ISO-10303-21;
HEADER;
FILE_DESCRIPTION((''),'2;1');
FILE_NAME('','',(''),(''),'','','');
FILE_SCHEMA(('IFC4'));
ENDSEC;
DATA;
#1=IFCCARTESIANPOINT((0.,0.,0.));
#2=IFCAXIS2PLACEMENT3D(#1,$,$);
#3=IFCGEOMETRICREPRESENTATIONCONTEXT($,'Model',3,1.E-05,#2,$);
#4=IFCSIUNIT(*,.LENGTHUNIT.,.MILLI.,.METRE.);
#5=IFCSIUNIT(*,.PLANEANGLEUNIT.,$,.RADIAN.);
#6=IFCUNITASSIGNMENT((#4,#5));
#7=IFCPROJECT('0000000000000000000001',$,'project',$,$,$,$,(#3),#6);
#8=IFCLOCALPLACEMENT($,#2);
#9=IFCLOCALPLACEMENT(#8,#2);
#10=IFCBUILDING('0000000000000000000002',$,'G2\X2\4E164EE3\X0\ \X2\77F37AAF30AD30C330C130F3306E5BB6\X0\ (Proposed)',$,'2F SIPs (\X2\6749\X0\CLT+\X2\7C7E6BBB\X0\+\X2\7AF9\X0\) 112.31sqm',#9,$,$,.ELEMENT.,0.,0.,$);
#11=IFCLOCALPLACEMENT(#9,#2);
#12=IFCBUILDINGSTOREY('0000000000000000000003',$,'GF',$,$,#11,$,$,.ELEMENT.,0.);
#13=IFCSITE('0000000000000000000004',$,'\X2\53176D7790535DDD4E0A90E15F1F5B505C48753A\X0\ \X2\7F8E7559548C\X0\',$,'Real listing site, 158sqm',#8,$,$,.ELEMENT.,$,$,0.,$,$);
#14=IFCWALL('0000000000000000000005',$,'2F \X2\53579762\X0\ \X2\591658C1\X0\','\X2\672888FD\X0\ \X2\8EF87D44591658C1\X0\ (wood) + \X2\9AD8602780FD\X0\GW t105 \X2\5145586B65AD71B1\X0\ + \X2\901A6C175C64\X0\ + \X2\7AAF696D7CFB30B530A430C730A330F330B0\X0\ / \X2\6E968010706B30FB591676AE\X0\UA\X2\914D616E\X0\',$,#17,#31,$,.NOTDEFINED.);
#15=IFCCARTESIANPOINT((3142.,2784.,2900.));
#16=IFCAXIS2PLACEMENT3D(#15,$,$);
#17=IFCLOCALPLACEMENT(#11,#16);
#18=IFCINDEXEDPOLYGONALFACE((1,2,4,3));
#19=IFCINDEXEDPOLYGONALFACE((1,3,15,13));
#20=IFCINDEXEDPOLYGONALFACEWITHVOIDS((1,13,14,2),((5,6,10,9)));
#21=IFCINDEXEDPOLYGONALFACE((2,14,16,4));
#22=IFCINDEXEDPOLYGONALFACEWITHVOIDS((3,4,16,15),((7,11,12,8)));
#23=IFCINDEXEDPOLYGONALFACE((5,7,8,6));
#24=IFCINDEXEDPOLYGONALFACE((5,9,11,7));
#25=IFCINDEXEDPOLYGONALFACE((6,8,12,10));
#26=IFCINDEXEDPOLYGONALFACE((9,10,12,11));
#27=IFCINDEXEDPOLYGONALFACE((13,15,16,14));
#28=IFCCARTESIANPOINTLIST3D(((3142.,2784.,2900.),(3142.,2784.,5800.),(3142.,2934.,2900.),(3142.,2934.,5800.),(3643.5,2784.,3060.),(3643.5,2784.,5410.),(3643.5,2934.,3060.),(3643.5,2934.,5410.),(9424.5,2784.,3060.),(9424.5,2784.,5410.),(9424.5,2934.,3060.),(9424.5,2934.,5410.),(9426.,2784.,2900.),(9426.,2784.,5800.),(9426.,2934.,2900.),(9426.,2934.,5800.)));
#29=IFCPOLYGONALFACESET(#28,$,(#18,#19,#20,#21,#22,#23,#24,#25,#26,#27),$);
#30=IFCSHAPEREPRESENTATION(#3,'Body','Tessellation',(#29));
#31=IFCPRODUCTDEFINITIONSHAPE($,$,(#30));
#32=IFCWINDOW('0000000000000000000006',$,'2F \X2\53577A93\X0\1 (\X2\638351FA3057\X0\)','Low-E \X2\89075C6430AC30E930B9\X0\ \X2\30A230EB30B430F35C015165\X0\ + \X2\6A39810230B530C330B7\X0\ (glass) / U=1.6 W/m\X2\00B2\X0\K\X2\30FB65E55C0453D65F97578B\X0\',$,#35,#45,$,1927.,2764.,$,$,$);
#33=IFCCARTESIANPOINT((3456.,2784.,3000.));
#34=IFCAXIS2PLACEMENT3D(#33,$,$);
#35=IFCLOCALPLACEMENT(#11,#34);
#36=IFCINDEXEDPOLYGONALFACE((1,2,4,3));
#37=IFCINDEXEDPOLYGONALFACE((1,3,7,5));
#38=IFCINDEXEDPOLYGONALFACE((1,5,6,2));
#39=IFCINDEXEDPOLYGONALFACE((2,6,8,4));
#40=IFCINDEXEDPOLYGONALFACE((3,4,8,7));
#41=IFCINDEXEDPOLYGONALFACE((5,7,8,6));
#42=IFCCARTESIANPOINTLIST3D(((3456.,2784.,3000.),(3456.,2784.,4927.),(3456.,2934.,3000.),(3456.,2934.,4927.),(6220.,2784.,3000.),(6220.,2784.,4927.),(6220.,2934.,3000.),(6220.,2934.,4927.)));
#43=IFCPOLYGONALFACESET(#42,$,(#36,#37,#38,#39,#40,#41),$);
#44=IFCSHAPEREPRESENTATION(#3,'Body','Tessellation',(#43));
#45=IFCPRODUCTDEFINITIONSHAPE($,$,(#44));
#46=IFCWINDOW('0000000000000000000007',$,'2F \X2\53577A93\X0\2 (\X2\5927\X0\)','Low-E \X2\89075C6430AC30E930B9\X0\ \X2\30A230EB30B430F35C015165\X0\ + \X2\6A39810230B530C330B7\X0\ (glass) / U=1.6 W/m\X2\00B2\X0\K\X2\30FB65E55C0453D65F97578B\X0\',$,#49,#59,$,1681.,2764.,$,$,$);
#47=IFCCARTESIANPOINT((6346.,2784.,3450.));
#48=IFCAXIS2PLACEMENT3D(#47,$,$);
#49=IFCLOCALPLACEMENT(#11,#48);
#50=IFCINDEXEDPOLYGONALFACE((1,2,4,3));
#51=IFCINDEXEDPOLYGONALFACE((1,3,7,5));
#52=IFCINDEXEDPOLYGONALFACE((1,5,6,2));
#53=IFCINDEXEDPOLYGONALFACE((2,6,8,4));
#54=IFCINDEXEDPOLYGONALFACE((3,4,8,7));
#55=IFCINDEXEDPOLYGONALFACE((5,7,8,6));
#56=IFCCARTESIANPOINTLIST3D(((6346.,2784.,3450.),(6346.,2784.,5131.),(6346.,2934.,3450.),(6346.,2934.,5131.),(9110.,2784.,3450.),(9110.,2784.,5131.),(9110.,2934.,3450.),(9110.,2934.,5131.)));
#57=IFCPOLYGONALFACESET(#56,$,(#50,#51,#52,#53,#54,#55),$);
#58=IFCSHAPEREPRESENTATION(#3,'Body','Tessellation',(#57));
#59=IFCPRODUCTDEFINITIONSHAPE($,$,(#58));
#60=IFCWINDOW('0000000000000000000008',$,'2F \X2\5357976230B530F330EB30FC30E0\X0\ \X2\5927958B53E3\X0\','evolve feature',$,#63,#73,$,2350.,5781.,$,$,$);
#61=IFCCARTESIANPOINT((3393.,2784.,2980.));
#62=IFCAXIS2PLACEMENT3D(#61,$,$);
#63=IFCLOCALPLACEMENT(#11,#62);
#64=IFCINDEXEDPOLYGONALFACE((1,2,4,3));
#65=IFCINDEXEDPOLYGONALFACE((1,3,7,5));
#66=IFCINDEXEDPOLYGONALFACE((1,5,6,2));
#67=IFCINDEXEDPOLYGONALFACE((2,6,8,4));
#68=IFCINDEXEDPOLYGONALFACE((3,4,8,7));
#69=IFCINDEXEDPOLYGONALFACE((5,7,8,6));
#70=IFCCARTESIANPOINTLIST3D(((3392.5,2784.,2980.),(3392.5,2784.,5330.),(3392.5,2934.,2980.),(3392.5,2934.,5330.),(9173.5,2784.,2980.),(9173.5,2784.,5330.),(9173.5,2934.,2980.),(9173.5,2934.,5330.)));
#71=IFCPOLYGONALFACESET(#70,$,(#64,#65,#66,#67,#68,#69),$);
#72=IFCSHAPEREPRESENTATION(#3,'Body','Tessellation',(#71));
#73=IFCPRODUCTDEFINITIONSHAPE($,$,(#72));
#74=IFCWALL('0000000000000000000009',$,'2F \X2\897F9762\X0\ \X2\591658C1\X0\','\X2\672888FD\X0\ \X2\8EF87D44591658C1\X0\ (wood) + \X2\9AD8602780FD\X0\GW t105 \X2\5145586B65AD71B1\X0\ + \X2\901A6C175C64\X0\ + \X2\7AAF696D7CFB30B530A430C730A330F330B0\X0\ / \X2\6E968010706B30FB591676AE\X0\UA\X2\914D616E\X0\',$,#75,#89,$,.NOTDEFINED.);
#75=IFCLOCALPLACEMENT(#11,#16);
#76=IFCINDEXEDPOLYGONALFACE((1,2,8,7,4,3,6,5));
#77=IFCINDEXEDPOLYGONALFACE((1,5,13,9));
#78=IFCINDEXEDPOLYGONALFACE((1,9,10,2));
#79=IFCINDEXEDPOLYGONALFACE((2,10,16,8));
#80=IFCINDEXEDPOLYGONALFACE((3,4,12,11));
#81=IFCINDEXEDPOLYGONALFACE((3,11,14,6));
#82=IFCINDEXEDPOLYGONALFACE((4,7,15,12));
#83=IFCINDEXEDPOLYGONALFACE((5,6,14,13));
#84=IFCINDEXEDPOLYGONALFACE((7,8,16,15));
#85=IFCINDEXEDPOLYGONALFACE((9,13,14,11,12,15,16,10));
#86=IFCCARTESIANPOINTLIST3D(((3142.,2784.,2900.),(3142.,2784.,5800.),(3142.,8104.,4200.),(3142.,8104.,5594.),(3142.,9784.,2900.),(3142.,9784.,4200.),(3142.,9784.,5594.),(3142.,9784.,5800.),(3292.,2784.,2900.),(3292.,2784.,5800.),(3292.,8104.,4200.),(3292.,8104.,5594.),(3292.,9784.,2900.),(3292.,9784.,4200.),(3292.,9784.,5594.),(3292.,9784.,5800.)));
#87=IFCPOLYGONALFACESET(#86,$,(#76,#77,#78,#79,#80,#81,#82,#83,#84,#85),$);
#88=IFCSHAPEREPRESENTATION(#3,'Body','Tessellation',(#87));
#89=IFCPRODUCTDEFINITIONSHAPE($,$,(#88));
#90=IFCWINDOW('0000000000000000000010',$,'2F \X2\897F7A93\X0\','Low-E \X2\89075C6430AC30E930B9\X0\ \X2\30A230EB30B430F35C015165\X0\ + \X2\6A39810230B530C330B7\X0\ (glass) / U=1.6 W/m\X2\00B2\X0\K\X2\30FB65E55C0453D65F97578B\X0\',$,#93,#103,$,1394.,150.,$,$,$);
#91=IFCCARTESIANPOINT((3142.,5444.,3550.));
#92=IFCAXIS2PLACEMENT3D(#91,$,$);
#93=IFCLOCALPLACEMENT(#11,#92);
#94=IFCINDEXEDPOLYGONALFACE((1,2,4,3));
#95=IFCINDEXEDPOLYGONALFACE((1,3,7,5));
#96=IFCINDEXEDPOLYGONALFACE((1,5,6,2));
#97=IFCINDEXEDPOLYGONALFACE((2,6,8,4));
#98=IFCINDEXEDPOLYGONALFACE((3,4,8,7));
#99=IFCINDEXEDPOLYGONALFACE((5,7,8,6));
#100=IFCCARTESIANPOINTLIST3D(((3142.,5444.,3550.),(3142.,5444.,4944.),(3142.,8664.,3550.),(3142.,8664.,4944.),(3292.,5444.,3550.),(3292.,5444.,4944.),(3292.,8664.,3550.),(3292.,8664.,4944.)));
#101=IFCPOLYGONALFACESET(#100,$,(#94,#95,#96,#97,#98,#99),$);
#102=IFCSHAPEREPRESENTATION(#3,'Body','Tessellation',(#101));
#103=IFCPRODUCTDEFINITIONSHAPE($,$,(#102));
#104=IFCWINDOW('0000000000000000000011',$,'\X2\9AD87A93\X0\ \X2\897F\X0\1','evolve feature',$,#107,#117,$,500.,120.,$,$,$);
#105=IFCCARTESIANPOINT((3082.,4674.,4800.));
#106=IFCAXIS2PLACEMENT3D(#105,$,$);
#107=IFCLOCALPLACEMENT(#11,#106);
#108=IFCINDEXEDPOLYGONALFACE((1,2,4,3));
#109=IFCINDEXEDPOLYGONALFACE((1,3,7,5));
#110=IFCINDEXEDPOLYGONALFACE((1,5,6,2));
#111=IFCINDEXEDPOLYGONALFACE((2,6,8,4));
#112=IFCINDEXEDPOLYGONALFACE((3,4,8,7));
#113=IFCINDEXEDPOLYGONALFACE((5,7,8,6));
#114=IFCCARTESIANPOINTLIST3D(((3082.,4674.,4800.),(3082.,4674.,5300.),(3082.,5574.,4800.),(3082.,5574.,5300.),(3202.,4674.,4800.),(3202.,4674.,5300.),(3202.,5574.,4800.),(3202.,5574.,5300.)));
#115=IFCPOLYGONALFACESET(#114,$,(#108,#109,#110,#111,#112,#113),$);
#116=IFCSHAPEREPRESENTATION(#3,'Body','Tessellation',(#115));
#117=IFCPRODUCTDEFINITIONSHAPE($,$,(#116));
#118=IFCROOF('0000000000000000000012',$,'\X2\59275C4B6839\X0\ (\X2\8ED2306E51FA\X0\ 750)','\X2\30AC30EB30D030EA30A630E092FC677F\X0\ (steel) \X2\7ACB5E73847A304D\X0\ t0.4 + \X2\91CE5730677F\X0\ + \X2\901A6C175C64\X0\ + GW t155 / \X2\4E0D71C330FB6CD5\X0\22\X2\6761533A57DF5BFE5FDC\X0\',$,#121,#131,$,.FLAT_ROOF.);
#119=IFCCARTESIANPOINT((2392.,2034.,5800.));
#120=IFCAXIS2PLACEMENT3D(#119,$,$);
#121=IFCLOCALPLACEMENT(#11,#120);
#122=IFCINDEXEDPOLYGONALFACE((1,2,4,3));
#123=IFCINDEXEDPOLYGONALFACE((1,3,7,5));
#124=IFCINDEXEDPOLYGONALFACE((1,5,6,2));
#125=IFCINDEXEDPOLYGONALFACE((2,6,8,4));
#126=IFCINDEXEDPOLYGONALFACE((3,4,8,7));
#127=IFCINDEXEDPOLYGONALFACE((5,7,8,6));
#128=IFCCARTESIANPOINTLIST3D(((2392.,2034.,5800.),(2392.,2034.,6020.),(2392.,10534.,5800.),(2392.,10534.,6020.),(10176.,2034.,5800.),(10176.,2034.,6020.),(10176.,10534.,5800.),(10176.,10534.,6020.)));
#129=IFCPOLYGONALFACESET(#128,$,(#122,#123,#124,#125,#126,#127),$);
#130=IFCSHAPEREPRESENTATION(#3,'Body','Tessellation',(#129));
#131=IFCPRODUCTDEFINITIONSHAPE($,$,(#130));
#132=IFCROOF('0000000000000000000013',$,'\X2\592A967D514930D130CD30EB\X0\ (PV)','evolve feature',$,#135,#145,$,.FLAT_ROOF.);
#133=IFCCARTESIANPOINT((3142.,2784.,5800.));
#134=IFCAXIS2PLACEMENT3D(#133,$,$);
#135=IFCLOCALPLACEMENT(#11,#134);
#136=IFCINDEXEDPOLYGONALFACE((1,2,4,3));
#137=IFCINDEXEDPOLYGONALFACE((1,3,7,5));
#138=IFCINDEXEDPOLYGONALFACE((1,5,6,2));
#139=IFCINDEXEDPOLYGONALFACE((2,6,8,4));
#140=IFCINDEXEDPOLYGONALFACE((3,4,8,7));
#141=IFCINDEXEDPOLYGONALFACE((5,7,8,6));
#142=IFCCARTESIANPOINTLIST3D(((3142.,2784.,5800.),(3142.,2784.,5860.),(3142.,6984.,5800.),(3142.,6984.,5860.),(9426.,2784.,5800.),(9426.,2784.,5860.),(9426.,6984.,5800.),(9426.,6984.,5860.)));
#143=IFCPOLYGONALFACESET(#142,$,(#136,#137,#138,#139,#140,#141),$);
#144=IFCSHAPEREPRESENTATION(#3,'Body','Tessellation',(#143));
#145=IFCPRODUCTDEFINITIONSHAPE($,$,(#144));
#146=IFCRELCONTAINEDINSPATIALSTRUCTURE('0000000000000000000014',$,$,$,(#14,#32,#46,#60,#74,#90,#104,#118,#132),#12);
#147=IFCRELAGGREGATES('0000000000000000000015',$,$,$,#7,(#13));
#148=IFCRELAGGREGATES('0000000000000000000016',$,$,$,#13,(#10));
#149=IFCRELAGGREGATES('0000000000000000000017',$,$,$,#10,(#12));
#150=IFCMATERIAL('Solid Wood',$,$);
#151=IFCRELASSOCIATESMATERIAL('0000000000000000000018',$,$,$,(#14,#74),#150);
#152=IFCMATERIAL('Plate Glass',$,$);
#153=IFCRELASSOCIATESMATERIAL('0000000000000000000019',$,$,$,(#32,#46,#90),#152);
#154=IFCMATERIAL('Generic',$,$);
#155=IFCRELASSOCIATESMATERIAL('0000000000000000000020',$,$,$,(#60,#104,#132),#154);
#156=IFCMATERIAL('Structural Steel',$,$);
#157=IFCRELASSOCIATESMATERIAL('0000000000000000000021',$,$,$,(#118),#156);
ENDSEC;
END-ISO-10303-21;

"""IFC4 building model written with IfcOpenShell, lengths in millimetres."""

from ifc_helpers import new_model, si_unit, frame, frame_2d, origin, place, context, project, spatial, rectangle, extrude, material, element, fill, save


model = new_model("IFC4")

# Units and contexts
model_context = context("Model", 3, precision=1e-05, world=origin())
ifc_project = project(units=[si_unit("LENGTHUNIT", "METRE", prefix="MILLI"), si_unit("PLANEANGLEUNIT", "RADIAN")], contexts=[model_context])

# Site, building, storey
site_placement = place(None, origin())
site = spatial("IfcSite", under=ifc_project, at=site_placement, Name="北海道川上郡弟子屈町 美留和", ObjectType="Real listing site, 158sqm", CompositionType="ELEMENT", RefElevation=0.0)
building_placement = place(site_placement, origin())
building = spatial("IfcBuilding", under=site, at=building_placement, Name="G2世代 石窯キッチンの家 (Proposed)", ObjectType="2F SIPs (杉CLT+籾殻+竹) 112.31sqm", CompositionType="ELEMENT", ElevationOfRefHeight=0.0, ElevationOfTerrain=0.0)
storey_placement = place(building_placement, origin())
storey = spatial("IfcBuildingStorey", under=building, at=storey_placement, Name="GF", CompositionType="ELEMENT", Elevation=0.0)

# Shared definitions
ifc_material_1 = material(Name="Solid Wood")
ifc_material_2 = material(Name="Generic")

# Shared definitions
ifc_material_3 = material(Name="Plate Glass")

# Walls, openings, windows
wall_1_placement = place(storey_placement, frame((3142.0, 2784.0, 2900.0)))
wall_1 = element("IfcWall", 1, at=wall_1_placement, inside=storey, material=ifc_material_1, Name="2F 南面 外壁", Description="木製 軸組外壁 (wood) + 高性能GW t105 充填断熱 + 通気層 + 窯業系サイディング / 準耐火・外皮UA配慮", PredefinedType="NOTDEFINED", context=model_context, shape_type="SweptSolid", body=[
    extrude(rectangle(XDim=6284.0, YDim=150.0, at=frame_2d((3142.0, 75.0))), frame((3142.0, 2784.0, 2900.0)), (0.0, 0.0, 1.0), 2900.0),
])
opening_1_placement = place(storey_placement, frame((3456.0, 2784.0, 3000.0)))
opening_1 = element("IfcOpeningElement", 2, at=opening_1_placement, cuts=wall_1, PredefinedType="NOTDEFINED", context=model_context, shape_type="SweptSolid", body=[
    extrude(rectangle(XDim=2764.0, YDim=150.0, at=frame_2d((1382.0, 75.0))), frame((3456.0, 2784.0, 3000.0)), (0.0, 0.0, 1.0), 1927.0),
])
opening_2_placement = place(storey_placement, frame((6346.0, 2784.0, 3450.0)))
opening_2 = element("IfcOpeningElement", 3, at=opening_2_placement, cuts=wall_1, PredefinedType="NOTDEFINED", context=model_context, shape_type="SweptSolid", body=[
    extrude(rectangle(XDim=2764.0, YDim=150.0, at=frame_2d((1382.0, 75.0))), frame((6346.0, 2784.0, 3450.0)), (0.0, 0.0, 1.0), 1681.0),
])
opening_3_placement = place(storey_placement, frame((3393.0, 2784.0, 2980.0)))
opening_3 = element("IfcOpeningElement", 4, at=opening_3_placement, cuts=wall_1, PredefinedType="NOTDEFINED", context=model_context, shape_type="SweptSolid", body=[
    extrude(rectangle(XDim=5781.0, YDim=150.0, at=frame_2d((2890.0, 75.0))), frame((3393.0, 2784.0, 2980.0)), (0.0, 0.0, 1.0), 2350.0),
])
window_1_placement = place(storey_placement, frame((3456.0, 2784.0, 3000.0)))
window_1 = element("IfcWindow", 5, at=window_1_placement, inside=storey, material=ifc_material_3, Name="2F 南窓1 (掃出し)", Description="Low-E 複層ガラス アルゴン封入 + 樹脂サッシ (glass) / U=1.6 W/m²K・日射取得型", OverallHeight=1927.0, OverallWidth=2764.0, context=model_context, shape_type="SweptSolid", body=[
    extrude(rectangle(XDim=2764.0, YDim=150.0, at=frame_2d((1382.0, 75.0))), frame((3456.0, 2784.0, 3000.0)), (0.0, 0.0, 1.0), 1927.0),
])
fill(opening_1, window_1)
window_2_placement = place(storey_placement, frame((6346.0, 2784.0, 3450.0)))
window_2 = element("IfcWindow", 6, at=window_2_placement, inside=storey, material=ifc_material_3, Name="2F 南窓2 (大)", Description="Low-E 複層ガラス アルゴン封入 + 樹脂サッシ (glass) / U=1.6 W/m²K・日射取得型", OverallHeight=1681.0, OverallWidth=2764.0, context=model_context, shape_type="SweptSolid", body=[
    extrude(rectangle(XDim=2764.0, YDim=150.0, at=frame_2d((1382.0, 75.0))), frame((6346.0, 2784.0, 3450.0)), (0.0, 0.0, 1.0), 1681.0),
])
fill(opening_2, window_2)
window_3_placement = place(storey_placement, frame((3393.0, 2784.0, 2980.0)))
window_3 = element("IfcWindow", 7, at=window_3_placement, inside=storey, material=ifc_material_2, Name="2F 南面サンルーム 大開口", Description="evolve feature", OverallHeight=2350.0, OverallWidth=5781.0, context=model_context, shape_type="SweptSolid", body=[
    extrude(rectangle(XDim=5781.0, YDim=150.0, at=frame_2d((2890.0, 75.0))), frame((3393.0, 2784.0, 2980.0)), (0.0, 0.0, 1.0), 2350.0),
])
fill(opening_3, window_3)
wall_2_placement = place(storey_placement, frame((3142.0, 2784.0, 2900.0)))
wall_2 = element("IfcWall", 8, at=wall_2_placement, inside=storey, material=ifc_material_1, Name="2F 西面 外壁", Description="木製 軸組外壁 (wood) + 高性能GW t105 充填断熱 + 通気層 + 窯業系サイディング / 準耐火・外皮UA配慮", PredefinedType="NOTDEFINED", context=model_context, shape_type="SweptSolid", body=[
    extrude(rectangle(XDim=150.0, YDim=7000.0, at=frame_2d((75.0, 3500.0))), frame((3142.0, 2784.0, 2900.0)), (0.0, 0.0, 1.0), 2900.0),
])
opening_4_placement = place(storey_placement, frame((3142.0, 5444.0, 3550.0)))
opening_4 = element("IfcOpeningElement", 9, at=opening_4_placement, cuts=wall_2, PredefinedType="NOTDEFINED", context=model_context, shape_type="SweptSolid", body=[
    extrude(rectangle(XDim=150.0, YDim=3220.0, at=frame_2d((75.0, 1610.0))), frame((3142.0, 5444.0, 3550.0)), (0.0, 0.0, 1.0), 1394.0),
])
opening_5_placement = place(storey_placement, frame((3082.0, 4674.0, 4800.0)))
opening_5 = element("IfcOpeningElement", 10, at=opening_5_placement, cuts=wall_2, PredefinedType="NOTDEFINED", context=model_context, shape_type="SweptSolid", body=[
    extrude(rectangle(XDim=120.0, YDim=900.0, at=frame_2d((60.0, 450.0))), frame((3082.0, 4674.0, 4800.0)), (0.0, 0.0, 1.0), 500.0),
])
window_4_placement = place(storey_placement, frame((3142.0, 5444.0, 3550.0)))
window_4 = element("IfcWindow", 11, at=window_4_placement, inside=storey, material=ifc_material_3, Name="2F 西窓", Description="Low-E 複層ガラス アルゴン封入 + 樹脂サッシ (glass) / U=1.6 W/m²K・日射取得型", OverallHeight=1394.0, OverallWidth=150.0, context=model_context, shape_type="SweptSolid", body=[
    extrude(rectangle(XDim=150.0, YDim=3220.0, at=frame_2d((75.0, 1610.0))), frame((3142.0, 5444.0, 3550.0)), (0.0, 0.0, 1.0), 1394.0),
])
fill(opening_4, window_4)
window_5_placement = place(storey_placement, frame((3082.0, 4674.0, 4800.0)))
window_5 = element("IfcWindow", 12, at=window_5_placement, inside=storey, material=ifc_material_2, Name="高窓 西1", Description="evolve feature", OverallHeight=500.0, OverallWidth=120.0, context=model_context, shape_type="SweptSolid", body=[
    extrude(rectangle(XDim=120.0, YDim=900.0, at=frame_2d((60.0, 450.0))), frame((3082.0, 4674.0, 4800.0)), (0.0, 0.0, 1.0), 500.0),
])
fill(opening_5, window_5)

# Roofs
ifc_material_4 = material(Name="Structural Steel")
roof_1_placement = place(storey_placement, frame((2392.0, 2034.0, 5800.0)))
element("IfcRoof", 13, at=roof_1_placement, inside=storey, material=ifc_material_4, Name="大屋根 (軒の出 750)", Description="ガルバリウム鋼板 (steel) 立平葺き t0.4 + 野地板 + 通気層 + GW t155 / 不燃・法22条区域対応", PredefinedType="FLAT_ROOF", context=model_context, shape_type="SweptSolid", body=[
    extrude(rectangle(XDim=7784.0, YDim=8500.0, at=frame_2d((3892.0, 4250.0))), frame((2392.0, 2034.0, 5800.0)), (0.0, 0.0, 1.0), 220.0),
])
roof_2_placement = place(storey_placement, frame((3142.0, 2784.0, 5800.0)))
element("IfcRoof", 14, at=roof_2_placement, inside=storey, material=ifc_material_2, Name="太陽光パネル (PV)", Description="evolve feature", PredefinedType="FLAT_ROOF", context=model_context, shape_type="SweptSolid", body=[
    extrude(rectangle(XDim=6284.0, YDim=4200.0, at=frame_2d((3142.0, 2100.0))), frame((3142.0, 2784.0, 5800.0)), (0.0, 0.0, 1.0), 60.0),
])

save(model, "model.ifc")
